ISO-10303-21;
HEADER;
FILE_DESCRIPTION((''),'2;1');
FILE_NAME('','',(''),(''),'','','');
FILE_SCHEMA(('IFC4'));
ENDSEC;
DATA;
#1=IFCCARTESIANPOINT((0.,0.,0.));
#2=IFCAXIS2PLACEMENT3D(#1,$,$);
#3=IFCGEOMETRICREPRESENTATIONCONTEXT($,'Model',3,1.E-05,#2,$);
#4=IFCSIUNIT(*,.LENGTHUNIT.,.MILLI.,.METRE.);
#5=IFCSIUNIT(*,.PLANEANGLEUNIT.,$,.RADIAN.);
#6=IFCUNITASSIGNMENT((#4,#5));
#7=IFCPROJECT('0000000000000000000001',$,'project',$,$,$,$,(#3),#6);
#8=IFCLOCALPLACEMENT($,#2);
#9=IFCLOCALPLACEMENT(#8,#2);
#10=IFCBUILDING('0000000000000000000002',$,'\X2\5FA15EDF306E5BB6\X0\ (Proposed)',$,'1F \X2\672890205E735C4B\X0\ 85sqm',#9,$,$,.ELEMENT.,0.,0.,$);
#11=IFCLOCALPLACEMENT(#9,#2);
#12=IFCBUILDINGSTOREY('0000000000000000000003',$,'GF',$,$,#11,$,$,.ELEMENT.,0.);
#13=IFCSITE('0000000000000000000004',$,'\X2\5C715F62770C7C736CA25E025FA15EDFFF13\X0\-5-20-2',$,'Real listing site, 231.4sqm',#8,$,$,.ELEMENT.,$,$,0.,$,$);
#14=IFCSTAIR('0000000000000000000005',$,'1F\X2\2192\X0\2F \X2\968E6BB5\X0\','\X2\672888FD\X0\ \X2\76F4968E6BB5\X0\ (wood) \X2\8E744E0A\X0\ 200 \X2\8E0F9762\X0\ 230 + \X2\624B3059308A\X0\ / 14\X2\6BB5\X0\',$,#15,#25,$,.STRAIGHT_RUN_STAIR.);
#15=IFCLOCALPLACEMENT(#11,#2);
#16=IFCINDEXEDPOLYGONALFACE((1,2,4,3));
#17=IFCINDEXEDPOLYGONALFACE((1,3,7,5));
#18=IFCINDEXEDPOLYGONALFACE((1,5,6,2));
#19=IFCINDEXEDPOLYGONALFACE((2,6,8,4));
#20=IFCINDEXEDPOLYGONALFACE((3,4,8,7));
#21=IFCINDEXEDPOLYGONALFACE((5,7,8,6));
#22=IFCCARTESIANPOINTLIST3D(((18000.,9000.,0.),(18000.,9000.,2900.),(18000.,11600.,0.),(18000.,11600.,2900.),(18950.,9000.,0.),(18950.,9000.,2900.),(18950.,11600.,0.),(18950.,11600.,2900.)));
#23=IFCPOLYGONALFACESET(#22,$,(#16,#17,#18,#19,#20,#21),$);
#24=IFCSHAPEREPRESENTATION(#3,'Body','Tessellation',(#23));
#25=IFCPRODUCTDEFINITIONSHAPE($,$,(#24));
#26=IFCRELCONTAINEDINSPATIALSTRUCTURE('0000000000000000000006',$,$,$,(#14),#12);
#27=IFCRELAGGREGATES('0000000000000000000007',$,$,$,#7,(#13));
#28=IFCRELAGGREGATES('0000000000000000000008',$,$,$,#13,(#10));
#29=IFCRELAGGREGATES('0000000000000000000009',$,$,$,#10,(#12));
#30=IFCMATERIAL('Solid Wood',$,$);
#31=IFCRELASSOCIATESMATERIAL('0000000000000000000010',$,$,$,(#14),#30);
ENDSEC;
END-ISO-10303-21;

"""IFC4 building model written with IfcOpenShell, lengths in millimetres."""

from ifc_helpers import new_model, si_unit, frame, frame_2d, origin, place, context, project, spatial, rectangle, extrude, material, element, save


model = new_model("IFC4")

# Units and contexts
model_context = context("Model", 3, precision=1e-05, world=origin())
ifc_project = project(units=[si_unit("LENGTHUNIT", "METRE", prefix="MILLI"), si_unit("PLANEANGLEUNIT", "RADIAN")], contexts=[model_context])

# Site, building, storey
site_placement = place(None, origin())
site = spatial("IfcSite", under=ifc_project, at=site_placement, Name="山形県米沢市御廟３-5-20-2", ObjectType="Real listing site, 231.4sqm", CompositionType="ELEMENT", RefElevation=0.0)
building_placement = place(site_placement, origin())
building = spatial("IfcBuilding", under=site, at=building_placement, Name="御廟の家 (Proposed)", ObjectType="1F 木造平屋 85sqm", CompositionType="ELEMENT", ElevationOfRefHeight=0.0, ElevationOfTerrain=0.0)
storey_placement = place(building_placement, origin())
storey = spatial("IfcBuildingStorey", under=building, at=storey_placement, Name="GF", CompositionType="ELEMENT", Elevation=0.0)

# Shared definitions
ifc_material_1 = material(Name="Solid Wood")

# Stair
stair_placement = place(storey_placement, frame((9000.0, 4500.0, 0.0)))
element("IfcStair", 1, at=stair_placement, inside=storey, material=ifc_material_1, Name="1F→2F 階段", Description="木製 直階段 (wood) 蹴上 200 踏面 230 + 手すり / 14段", PredefinedType="STRAIGHT_RUN_STAIR", context=model_context, shape_type="SweptSolid", body=[
    extrude(rectangle(XDim=950.0, YDim=2600.0, at=frame_2d((475.0, 1300.0))), frame((9000.0, 4500.0, 0.0)), (0.0, 0.0, 1.0), 2900.0),
])

save(model, "model.ifc")
